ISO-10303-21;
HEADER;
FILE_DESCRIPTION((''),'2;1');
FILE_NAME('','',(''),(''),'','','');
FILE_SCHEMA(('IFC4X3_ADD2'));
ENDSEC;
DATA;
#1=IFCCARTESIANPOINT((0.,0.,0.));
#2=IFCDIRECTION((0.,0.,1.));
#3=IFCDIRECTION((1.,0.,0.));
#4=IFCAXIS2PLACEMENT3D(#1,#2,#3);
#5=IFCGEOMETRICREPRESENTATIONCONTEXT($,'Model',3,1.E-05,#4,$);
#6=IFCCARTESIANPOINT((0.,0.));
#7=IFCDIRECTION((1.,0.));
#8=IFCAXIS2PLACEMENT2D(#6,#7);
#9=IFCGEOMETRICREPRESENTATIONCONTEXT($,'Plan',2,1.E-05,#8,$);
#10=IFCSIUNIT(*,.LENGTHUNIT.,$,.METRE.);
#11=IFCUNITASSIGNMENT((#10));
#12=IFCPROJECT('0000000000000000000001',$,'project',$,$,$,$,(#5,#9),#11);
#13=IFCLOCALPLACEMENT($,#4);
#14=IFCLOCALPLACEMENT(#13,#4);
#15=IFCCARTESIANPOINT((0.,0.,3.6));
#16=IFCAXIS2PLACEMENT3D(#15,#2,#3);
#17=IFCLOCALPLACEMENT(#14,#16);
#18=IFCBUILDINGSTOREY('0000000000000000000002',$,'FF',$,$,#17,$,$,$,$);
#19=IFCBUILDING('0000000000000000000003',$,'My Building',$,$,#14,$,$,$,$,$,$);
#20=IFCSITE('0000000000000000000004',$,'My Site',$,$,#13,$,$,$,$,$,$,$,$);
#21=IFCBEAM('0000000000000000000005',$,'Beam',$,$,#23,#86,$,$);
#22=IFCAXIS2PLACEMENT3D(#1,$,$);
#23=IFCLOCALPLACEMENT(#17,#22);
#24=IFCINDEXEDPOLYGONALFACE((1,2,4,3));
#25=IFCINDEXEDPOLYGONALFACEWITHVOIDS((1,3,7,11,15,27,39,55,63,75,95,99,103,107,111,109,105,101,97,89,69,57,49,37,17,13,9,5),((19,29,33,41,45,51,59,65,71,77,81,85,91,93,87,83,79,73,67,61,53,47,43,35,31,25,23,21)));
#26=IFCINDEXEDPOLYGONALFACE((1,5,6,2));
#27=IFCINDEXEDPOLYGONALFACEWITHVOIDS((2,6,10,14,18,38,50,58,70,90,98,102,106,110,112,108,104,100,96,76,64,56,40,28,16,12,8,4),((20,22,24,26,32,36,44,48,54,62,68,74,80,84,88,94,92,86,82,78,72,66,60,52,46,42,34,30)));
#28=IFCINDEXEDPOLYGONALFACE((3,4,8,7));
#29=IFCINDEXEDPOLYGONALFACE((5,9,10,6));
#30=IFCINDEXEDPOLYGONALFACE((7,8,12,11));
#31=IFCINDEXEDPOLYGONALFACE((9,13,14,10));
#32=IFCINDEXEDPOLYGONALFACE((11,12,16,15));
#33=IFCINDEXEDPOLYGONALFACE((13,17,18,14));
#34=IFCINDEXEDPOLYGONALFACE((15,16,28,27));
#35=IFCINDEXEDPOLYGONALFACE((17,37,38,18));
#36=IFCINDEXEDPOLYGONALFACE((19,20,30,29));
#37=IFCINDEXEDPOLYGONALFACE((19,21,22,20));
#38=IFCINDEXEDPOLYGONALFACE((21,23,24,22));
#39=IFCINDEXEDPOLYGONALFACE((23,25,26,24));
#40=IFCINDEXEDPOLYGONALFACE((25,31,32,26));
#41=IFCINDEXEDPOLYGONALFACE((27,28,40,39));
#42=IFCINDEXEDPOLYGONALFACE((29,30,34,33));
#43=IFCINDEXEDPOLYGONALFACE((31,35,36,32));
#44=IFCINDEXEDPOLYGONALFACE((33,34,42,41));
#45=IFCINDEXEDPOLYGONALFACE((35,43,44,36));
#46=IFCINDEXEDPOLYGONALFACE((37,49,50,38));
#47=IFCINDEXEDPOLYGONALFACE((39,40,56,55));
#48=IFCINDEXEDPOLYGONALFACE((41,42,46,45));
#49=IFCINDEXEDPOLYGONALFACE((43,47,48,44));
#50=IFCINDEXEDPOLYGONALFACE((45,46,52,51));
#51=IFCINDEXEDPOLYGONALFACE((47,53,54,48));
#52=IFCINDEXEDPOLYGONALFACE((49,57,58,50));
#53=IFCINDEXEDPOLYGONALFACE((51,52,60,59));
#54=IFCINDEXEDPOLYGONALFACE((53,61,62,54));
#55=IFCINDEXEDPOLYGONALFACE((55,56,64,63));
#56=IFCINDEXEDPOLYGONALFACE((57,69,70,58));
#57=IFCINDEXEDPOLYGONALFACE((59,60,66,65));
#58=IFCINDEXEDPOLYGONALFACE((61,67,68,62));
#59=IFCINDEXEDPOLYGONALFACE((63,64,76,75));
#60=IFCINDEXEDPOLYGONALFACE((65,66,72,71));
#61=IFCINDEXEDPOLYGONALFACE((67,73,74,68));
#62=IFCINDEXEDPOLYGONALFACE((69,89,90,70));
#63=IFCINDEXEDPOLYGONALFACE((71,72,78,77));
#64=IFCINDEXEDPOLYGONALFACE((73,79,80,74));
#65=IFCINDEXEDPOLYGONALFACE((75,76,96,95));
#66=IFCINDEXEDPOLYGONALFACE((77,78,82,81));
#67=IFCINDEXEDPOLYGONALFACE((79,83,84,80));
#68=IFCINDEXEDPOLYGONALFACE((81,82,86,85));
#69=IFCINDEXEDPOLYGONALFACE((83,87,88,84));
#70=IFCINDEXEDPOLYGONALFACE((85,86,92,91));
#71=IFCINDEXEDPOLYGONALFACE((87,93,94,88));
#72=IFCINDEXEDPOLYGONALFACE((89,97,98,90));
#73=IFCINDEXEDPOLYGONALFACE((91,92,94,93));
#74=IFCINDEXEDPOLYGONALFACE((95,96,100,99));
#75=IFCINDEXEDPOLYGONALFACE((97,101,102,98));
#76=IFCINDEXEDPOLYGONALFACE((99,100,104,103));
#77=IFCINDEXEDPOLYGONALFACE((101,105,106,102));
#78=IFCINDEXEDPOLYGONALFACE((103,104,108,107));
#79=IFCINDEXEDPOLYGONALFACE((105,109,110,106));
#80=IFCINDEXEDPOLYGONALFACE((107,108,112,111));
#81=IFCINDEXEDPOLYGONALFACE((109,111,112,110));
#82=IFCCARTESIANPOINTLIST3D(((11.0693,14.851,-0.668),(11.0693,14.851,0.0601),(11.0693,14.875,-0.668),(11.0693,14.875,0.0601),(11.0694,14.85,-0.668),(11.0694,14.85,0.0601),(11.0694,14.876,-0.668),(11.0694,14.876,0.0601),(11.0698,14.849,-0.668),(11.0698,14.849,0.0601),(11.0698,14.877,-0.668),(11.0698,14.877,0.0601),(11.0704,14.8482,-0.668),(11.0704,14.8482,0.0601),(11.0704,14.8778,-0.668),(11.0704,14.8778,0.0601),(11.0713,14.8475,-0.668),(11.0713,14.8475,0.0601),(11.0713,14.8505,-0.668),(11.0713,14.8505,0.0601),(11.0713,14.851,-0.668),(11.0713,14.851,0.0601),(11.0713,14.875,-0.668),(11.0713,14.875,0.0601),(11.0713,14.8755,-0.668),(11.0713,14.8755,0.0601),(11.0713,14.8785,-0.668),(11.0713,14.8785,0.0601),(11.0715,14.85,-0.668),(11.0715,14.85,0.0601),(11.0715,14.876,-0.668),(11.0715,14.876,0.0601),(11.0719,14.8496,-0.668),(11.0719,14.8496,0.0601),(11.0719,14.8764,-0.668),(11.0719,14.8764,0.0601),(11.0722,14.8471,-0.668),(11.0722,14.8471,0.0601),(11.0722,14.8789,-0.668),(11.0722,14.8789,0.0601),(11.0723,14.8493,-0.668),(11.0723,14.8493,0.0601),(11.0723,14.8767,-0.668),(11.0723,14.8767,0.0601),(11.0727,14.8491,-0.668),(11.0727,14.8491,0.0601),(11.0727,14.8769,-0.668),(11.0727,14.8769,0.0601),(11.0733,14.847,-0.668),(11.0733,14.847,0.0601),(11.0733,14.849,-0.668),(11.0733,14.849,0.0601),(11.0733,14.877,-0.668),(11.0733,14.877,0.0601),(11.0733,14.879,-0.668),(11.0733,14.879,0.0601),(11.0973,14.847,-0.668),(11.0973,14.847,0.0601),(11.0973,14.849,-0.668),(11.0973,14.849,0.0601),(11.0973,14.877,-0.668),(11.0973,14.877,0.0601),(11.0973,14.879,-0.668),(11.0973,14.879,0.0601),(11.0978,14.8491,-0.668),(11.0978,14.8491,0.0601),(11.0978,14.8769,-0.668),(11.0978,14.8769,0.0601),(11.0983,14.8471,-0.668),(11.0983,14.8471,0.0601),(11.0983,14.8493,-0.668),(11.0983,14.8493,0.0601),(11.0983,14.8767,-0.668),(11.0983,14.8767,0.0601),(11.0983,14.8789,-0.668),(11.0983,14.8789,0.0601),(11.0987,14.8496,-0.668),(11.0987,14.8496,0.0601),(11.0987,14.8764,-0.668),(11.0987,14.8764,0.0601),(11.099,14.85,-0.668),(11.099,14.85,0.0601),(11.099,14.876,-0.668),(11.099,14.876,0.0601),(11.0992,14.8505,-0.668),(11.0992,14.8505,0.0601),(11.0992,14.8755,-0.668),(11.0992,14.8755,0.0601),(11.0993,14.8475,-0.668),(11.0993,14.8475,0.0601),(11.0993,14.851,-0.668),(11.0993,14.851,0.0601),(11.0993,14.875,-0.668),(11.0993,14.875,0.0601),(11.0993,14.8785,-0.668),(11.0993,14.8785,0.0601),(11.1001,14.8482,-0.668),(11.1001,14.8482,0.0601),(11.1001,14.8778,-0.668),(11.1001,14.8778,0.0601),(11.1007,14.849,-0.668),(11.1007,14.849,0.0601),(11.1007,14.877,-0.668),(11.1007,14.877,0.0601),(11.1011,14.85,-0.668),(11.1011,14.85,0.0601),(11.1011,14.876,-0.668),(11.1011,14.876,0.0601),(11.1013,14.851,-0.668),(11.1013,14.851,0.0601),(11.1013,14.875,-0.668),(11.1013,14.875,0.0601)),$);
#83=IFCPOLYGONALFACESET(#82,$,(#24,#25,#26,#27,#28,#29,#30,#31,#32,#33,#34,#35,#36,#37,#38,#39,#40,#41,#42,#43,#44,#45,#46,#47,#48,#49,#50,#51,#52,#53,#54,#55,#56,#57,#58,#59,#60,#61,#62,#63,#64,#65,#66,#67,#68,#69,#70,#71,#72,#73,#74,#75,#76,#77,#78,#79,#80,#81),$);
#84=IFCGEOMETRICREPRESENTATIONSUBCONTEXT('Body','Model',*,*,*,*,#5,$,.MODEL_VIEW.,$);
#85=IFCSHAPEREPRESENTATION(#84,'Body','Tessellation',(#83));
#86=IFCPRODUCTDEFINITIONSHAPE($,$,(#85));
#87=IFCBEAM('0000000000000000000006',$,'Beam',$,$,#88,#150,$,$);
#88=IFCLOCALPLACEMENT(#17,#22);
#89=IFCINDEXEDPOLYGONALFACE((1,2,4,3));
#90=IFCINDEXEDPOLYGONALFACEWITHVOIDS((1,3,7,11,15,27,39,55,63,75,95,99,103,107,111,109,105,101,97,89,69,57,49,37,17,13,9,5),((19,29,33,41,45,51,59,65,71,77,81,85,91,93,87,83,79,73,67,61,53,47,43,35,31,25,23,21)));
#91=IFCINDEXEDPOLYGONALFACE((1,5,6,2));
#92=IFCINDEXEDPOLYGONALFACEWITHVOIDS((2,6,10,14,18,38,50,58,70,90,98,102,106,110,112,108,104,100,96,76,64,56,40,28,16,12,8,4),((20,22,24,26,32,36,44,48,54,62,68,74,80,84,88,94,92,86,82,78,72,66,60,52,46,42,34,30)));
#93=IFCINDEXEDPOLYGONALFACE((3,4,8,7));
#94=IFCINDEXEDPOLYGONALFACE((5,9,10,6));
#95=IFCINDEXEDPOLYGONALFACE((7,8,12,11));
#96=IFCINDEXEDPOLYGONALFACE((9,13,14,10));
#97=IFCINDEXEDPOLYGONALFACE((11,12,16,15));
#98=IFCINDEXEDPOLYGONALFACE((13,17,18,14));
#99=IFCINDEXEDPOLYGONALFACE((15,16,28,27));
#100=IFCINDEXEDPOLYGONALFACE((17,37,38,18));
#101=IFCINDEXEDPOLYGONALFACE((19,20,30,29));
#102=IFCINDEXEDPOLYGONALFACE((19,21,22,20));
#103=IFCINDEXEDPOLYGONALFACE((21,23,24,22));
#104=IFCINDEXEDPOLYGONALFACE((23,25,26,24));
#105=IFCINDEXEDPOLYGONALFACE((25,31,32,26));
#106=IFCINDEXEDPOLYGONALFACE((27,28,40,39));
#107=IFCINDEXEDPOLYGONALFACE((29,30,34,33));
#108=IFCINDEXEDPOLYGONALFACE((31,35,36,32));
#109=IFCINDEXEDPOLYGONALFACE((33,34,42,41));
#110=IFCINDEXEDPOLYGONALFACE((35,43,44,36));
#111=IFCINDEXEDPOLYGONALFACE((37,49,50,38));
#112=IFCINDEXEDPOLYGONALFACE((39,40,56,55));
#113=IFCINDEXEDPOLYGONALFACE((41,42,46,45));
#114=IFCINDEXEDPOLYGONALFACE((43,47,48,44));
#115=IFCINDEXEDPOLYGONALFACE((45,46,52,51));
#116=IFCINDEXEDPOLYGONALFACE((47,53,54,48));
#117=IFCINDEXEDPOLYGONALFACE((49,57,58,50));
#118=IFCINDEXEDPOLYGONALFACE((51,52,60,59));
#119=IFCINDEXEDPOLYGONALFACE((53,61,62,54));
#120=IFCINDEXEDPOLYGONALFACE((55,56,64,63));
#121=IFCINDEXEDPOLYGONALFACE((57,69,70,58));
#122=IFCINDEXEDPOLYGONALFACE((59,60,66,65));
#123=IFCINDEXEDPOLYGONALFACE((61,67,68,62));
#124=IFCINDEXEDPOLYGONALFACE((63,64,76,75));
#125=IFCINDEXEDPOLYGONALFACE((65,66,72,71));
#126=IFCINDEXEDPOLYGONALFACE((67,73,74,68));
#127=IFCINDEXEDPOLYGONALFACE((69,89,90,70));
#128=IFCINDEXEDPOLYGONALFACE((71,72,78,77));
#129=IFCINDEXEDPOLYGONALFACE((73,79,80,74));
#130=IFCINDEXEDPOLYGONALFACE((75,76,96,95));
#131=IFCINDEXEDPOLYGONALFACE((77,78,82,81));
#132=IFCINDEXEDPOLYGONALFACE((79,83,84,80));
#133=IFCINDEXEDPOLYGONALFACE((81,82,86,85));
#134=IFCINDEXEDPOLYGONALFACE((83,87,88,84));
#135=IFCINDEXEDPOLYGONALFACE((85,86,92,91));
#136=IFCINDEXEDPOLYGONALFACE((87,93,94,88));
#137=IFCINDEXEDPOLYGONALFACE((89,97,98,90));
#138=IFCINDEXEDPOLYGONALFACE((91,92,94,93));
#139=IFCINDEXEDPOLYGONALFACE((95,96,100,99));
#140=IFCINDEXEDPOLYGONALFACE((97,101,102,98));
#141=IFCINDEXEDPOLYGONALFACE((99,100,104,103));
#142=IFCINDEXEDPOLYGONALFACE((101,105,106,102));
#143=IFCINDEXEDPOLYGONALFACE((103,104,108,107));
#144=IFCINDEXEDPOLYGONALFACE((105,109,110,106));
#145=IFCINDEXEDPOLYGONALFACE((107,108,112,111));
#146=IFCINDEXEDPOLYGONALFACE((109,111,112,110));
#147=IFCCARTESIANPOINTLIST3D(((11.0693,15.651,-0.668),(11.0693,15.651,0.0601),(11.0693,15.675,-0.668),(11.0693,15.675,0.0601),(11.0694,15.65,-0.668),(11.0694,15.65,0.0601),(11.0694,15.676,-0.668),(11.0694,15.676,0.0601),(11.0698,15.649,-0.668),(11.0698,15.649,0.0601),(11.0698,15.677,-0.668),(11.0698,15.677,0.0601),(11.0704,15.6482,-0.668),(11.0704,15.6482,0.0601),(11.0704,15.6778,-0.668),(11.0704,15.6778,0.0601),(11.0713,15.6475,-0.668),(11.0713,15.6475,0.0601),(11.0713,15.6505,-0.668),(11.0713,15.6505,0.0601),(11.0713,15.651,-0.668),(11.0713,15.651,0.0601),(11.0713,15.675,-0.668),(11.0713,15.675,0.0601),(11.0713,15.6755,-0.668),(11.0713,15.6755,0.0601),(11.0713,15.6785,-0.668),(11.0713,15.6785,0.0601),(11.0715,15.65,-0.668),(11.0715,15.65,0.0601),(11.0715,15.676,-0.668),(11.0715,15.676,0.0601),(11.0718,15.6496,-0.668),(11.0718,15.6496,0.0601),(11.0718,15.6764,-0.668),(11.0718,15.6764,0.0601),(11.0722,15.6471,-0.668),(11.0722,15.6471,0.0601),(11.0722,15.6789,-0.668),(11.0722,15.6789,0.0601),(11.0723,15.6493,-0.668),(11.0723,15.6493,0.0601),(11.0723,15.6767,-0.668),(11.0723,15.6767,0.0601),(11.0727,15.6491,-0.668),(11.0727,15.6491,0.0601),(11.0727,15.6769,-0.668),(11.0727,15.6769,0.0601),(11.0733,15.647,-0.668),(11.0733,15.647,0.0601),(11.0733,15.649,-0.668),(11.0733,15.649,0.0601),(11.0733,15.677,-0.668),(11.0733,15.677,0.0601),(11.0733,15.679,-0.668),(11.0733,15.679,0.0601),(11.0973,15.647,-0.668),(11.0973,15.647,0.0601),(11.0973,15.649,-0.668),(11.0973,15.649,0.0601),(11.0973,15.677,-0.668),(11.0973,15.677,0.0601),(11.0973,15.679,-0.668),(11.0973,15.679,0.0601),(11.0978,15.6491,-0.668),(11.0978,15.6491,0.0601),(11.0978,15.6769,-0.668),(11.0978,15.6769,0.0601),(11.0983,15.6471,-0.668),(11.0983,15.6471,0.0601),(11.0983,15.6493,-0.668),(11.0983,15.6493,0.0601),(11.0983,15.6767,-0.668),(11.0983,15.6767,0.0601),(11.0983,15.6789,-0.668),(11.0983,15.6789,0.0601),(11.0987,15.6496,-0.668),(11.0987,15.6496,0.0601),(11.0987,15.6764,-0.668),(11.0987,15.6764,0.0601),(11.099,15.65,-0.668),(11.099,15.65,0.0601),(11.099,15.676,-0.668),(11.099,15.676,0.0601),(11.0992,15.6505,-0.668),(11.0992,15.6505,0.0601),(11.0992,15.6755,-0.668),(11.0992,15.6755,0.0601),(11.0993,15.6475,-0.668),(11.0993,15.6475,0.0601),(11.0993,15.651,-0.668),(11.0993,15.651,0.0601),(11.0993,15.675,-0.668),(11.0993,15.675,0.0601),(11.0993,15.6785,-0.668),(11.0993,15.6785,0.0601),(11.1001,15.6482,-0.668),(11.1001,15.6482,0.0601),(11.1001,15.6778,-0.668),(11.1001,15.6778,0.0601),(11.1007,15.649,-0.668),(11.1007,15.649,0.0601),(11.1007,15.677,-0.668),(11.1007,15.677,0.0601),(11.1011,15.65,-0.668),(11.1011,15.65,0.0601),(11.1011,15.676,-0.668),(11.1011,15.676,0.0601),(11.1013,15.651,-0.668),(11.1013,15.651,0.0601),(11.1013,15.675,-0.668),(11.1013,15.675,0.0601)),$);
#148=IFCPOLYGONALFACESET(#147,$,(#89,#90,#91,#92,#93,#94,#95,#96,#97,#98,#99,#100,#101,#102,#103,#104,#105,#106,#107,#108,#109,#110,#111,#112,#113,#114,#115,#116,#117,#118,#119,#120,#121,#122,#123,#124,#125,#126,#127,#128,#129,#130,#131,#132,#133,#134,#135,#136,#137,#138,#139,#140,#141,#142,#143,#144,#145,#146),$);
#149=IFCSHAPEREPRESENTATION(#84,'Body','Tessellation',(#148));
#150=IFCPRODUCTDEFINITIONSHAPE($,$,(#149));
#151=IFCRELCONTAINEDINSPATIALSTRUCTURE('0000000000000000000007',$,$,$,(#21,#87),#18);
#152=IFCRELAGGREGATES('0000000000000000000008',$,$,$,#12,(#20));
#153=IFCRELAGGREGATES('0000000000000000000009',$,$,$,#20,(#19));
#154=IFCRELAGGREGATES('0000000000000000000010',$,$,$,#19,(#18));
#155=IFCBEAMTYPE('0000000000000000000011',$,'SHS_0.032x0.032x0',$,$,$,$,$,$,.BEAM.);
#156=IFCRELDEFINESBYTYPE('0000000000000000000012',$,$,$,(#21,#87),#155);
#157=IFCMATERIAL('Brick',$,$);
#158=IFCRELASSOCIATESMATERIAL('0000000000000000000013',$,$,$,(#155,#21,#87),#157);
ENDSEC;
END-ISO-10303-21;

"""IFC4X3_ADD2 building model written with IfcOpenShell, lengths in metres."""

from ifc_helpers import new_model, si_unit, frame, origin_with_axes, origin_2d_with_axis, place, context, subcontext, project, spatial, hollow_rectangle, extrude, material, material_profile, profile_set, profile_usage, type_object, element, save


model = new_model("IFC4X3_ADD2")

# Units and contexts
model_context = context("Model", 3, precision=1e-05, world=origin_with_axes())
plan_context = context("Plan", 2, precision=1e-05, world=origin_2d_with_axis())
body_context_1 = subcontext(model_context, "Body", "Model", "MODEL_VIEW")
ifc_project = project(units=[si_unit("LENGTHUNIT", "METRE")], contexts=[model_context, plan_context])

# Site, building, storey
site_placement = place(None, origin_with_axes())
site = spatial("IfcSite", under=ifc_project, at=site_placement, Name="My Site")
building_placement = place(site_placement, origin_with_axes())
building = spatial("IfcBuilding", under=site, at=building_placement, Name="My Building")
storey_placement = place(building_placement, frame((0.0, 0.0, 3.6), z_axis=(0.0, 0.0, 1.0), x_axis=(1.0, 0.0, 0.0)))
storey = spatial("IfcBuildingStorey", under=building, at=storey_placement, Name="FF")

# Beams
ifc_material_1 = material(Name="Brick")
ifc_material_profile_1 = material_profile(ifc_material_1, hollow_rectangle(XDim=0.032, YDim=0.032, WallThickness=0.002, InnerFilletRadius=0.002, OuterFilletRadius=0.004))
ifc_profile_set_1 = profile_set([ifc_material_profile_1])
beam_type_1 = type_object("IfcBeamType", Name="SHS_0.032x0.032x0", PredefinedType="BEAM", material=ifc_profile_set_1)
ifc_material_profile_2 = material_profile(ifc_material_1, hollow_rectangle(XDim=0.032, YDim=0.032, WallThickness=0.002, InnerFilletRadius=0.002, OuterFilletRadius=0.004))
ifc_profile_set_2 = profile_set([ifc_material_profile_2])
ifc_profile_usage_1 = profile_usage(ifc_profile_set_2, cardinal=5)
beam_1_placement = place(storey_placement, frame((11.0853, 14.863, -0.668), z_axis=(0.0, 0.0, 1.0), x_axis=(1.0, 0.0, 0.0)))
element("IfcBeam", 1, at=beam_1_placement, inside=storey, type_object=beam_type_1, material=ifc_profile_usage_1, Name="Beam", context=body_context_1, shape_type="SweptSolid", body=[
    extrude(hollow_rectangle(XDim=0.032, YDim=0.032, WallThickness=0.002, InnerFilletRadius=0.002, OuterFilletRadius=0.004), origin_with_axes(), (0.0, 0.0, 1.0), 0.7281),
])
ifc_profile_usage_2 = profile_usage(ifc_profile_set_2, cardinal=5)
beam_2_placement = place(storey_placement, frame((11.0853, 15.663, -0.668), z_axis=(0.0, 0.0, 1.0), x_axis=(1.0, 0.0, 0.0)))
element("IfcBeam", 2, at=beam_2_placement, inside=storey, type_object=beam_type_1, material=ifc_profile_usage_2, Name="Beam", context=body_context_1, shape_type="SweptSolid", body=[
    extrude(hollow_rectangle(XDim=0.032, YDim=0.032, WallThickness=0.002, InnerFilletRadius=0.002, OuterFilletRadius=0.004), origin_with_axes(), (0.0, 0.0, 1.0), 0.7281),
])

save(model, "model.ifc")
